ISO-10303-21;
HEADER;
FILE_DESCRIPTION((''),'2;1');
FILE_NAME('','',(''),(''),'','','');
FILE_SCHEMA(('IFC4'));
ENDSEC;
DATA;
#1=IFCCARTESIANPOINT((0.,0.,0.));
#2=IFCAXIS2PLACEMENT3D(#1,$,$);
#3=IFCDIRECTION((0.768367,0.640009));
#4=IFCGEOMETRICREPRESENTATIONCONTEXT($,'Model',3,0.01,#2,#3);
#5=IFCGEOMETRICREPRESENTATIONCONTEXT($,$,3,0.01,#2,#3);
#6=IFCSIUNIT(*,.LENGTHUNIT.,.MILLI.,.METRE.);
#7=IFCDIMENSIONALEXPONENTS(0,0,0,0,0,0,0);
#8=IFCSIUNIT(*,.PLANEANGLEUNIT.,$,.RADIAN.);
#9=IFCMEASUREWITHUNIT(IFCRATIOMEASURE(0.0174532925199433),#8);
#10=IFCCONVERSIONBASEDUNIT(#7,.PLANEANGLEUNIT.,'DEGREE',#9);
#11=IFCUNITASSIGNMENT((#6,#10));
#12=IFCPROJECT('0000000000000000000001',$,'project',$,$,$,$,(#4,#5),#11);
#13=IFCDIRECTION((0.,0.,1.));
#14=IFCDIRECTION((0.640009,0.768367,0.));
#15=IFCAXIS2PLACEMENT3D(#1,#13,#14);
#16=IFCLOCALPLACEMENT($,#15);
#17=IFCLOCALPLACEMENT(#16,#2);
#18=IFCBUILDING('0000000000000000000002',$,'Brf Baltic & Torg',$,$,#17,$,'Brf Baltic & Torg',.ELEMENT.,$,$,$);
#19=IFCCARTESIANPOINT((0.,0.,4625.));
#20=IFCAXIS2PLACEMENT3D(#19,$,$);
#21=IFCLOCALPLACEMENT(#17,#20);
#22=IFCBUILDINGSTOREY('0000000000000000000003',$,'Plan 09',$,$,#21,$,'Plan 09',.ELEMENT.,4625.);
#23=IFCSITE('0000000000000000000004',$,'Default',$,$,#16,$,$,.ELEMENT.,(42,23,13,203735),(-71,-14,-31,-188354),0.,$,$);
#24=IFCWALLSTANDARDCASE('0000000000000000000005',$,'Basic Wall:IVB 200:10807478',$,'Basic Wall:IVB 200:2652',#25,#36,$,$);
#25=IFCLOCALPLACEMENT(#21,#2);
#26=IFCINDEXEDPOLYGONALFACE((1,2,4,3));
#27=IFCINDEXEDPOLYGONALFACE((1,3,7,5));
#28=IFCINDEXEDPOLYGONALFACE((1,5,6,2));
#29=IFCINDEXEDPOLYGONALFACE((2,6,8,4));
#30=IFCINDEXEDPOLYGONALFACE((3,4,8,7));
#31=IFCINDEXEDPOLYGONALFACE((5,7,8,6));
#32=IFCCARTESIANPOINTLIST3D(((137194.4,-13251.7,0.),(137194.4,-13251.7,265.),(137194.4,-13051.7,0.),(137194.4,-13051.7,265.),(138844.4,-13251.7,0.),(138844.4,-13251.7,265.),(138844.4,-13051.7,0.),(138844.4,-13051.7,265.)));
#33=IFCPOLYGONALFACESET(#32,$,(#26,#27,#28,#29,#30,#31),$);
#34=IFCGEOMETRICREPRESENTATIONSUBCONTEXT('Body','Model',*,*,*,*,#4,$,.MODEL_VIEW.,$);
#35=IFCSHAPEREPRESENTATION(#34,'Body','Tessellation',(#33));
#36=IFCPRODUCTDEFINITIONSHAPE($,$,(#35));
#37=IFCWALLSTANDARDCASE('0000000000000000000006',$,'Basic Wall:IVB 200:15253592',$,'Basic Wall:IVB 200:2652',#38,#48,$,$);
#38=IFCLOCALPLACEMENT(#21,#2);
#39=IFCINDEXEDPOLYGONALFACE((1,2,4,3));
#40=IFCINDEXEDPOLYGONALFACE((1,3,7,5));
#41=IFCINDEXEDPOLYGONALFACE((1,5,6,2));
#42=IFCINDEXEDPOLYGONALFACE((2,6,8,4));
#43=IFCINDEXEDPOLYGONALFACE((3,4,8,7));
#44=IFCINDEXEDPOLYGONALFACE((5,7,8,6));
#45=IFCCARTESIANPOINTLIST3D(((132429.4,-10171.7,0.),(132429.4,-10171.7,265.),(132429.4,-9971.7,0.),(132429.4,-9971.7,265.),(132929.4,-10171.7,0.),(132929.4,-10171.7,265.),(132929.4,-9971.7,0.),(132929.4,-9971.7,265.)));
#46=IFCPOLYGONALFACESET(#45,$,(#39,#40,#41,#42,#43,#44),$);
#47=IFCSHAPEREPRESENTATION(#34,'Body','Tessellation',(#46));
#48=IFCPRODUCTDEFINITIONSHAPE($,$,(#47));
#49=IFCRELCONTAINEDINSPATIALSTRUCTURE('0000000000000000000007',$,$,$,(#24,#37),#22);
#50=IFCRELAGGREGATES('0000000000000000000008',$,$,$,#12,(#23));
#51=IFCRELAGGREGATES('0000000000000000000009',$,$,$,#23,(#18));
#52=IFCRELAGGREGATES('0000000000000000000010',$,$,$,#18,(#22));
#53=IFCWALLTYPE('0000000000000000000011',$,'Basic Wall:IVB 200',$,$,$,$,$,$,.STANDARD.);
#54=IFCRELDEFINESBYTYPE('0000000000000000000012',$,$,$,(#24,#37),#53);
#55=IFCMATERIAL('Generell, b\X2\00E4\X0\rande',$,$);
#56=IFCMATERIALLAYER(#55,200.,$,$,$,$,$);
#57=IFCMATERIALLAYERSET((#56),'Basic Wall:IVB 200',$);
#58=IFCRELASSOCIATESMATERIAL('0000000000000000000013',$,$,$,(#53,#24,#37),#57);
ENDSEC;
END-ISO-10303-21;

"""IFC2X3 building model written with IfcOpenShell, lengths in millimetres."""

from ifc_helpers import new_model, entity, si_unit, converted_unit, direction, frame, frame_2d, origin, place, context, subcontext, project, spatial, rectangle, extrude, clip, halfspace, material, layer, layer_set, layer_usage, type_object, element, save


model = new_model("IFC2X3")

# Units and contexts
model_context = context("Model", 3, precision=0.01, world=origin(), true_north=direction((0.768367, 0.640009)))
context_of_model = context(None, 3, precision=0.01, world=origin(), true_north=direction((0.768367, 0.640009)))
body_context = subcontext(model_context, "Body", "Model", "MODEL_VIEW")
ifc_project = project(units=[si_unit("LENGTHUNIT", "METRE", prefix="MILLI"), converted_unit("PLANEANGLEUNIT", "DEGREE", entity("IfcRatioMeasure", 0.0174532925199433), si_unit("PLANEANGLEUNIT", "RADIAN"), dimensions=[0, 0, 0, 0, 0, 0, 0])], contexts=[model_context, context_of_model])

# Site, building, storey
site_placement = place(None, frame((0.0, 0.0, 0.0), z_axis=(0.0, 0.0, 1.0), x_axis=(0.640009, 0.768367, 0.0)))
site = spatial("IfcSite", under=ifc_project, at=site_placement, Name="Default", CompositionType="ELEMENT", RefLatitude=(42, 23, 13, 203735), RefLongitude=(-71, -14, -31, -188354), RefElevation=0.0)
building_placement = place(site_placement, origin())
building = spatial("IfcBuilding", under=site, at=building_placement, Name="Brf Baltic & Torg", LongName="Brf Baltic & Torg", CompositionType="ELEMENT")
storey_placement = place(building_placement, frame((0.0, 0.0, 4625.0)))
storey = spatial("IfcBuildingStorey", under=building, at=storey_placement, Name="Plan 09", LongName="Plan 09", CompositionType="ELEMENT", Elevation=4625.0)

# Shared definitions
ifc_material_1 = material(Name="Generell, bärande")
ifc_layer = layer(ifc_material_1, 200.0)
ifc_layer_set = layer_set([ifc_layer], Name="Basic Wall:IVB 200")
wall_type = type_object("IfcWallType", Name="Basic Wall:IVB 200", PredefinedType="STANDARD", material=ifc_layer_set)

# Wall
ifc_layer_usage_1 = layer_usage(ifc_layer_set, "AXIS2", "NEGATIVE", 100.0)
wall_1_placement = place(storey_placement, frame((137194.4, -13151.7, 0.0)))
element("IfcWallStandardCase", 1, at=wall_1_placement, inside=storey, type_object=wall_type, material=ifc_layer_usage_1, Name="Basic Wall:IVB 200:10807478", ObjectType="Basic Wall:IVB 200:2652", context=body_context, shape_type="Clipping", body=[
    clip(extrude(rectangle(XDim=1650.0, YDim=200.0, at=frame_2d((825.0, 0.0), x_axis=(-1.0, 0.0))), origin(), (0.0, 0.0, 1.0), 265.0), halfspace(origin(), True)),
])

# Wall
ifc_layer_usage_2 = layer_usage(ifc_layer_set, "AXIS2", "NEGATIVE", 100.0)
wall_2_placement = place(storey_placement, frame((132429.4, -10071.7, 0.0)))
element("IfcWallStandardCase", 2, at=wall_2_placement, inside=storey, type_object=wall_type, material=ifc_layer_usage_2, Name="Basic Wall:IVB 200:15253592", ObjectType="Basic Wall:IVB 200:2652", context=body_context, shape_type="Clipping", body=[
    clip(extrude(rectangle(XDim=500.0, YDim=200.0, at=frame_2d((250.0, 0.0), x_axis=(-1.0, 0.0))), origin(), (0.0, 0.0, 1.0), 265.0), halfspace(origin(), True)),
])

save(model, "model.ifc")
